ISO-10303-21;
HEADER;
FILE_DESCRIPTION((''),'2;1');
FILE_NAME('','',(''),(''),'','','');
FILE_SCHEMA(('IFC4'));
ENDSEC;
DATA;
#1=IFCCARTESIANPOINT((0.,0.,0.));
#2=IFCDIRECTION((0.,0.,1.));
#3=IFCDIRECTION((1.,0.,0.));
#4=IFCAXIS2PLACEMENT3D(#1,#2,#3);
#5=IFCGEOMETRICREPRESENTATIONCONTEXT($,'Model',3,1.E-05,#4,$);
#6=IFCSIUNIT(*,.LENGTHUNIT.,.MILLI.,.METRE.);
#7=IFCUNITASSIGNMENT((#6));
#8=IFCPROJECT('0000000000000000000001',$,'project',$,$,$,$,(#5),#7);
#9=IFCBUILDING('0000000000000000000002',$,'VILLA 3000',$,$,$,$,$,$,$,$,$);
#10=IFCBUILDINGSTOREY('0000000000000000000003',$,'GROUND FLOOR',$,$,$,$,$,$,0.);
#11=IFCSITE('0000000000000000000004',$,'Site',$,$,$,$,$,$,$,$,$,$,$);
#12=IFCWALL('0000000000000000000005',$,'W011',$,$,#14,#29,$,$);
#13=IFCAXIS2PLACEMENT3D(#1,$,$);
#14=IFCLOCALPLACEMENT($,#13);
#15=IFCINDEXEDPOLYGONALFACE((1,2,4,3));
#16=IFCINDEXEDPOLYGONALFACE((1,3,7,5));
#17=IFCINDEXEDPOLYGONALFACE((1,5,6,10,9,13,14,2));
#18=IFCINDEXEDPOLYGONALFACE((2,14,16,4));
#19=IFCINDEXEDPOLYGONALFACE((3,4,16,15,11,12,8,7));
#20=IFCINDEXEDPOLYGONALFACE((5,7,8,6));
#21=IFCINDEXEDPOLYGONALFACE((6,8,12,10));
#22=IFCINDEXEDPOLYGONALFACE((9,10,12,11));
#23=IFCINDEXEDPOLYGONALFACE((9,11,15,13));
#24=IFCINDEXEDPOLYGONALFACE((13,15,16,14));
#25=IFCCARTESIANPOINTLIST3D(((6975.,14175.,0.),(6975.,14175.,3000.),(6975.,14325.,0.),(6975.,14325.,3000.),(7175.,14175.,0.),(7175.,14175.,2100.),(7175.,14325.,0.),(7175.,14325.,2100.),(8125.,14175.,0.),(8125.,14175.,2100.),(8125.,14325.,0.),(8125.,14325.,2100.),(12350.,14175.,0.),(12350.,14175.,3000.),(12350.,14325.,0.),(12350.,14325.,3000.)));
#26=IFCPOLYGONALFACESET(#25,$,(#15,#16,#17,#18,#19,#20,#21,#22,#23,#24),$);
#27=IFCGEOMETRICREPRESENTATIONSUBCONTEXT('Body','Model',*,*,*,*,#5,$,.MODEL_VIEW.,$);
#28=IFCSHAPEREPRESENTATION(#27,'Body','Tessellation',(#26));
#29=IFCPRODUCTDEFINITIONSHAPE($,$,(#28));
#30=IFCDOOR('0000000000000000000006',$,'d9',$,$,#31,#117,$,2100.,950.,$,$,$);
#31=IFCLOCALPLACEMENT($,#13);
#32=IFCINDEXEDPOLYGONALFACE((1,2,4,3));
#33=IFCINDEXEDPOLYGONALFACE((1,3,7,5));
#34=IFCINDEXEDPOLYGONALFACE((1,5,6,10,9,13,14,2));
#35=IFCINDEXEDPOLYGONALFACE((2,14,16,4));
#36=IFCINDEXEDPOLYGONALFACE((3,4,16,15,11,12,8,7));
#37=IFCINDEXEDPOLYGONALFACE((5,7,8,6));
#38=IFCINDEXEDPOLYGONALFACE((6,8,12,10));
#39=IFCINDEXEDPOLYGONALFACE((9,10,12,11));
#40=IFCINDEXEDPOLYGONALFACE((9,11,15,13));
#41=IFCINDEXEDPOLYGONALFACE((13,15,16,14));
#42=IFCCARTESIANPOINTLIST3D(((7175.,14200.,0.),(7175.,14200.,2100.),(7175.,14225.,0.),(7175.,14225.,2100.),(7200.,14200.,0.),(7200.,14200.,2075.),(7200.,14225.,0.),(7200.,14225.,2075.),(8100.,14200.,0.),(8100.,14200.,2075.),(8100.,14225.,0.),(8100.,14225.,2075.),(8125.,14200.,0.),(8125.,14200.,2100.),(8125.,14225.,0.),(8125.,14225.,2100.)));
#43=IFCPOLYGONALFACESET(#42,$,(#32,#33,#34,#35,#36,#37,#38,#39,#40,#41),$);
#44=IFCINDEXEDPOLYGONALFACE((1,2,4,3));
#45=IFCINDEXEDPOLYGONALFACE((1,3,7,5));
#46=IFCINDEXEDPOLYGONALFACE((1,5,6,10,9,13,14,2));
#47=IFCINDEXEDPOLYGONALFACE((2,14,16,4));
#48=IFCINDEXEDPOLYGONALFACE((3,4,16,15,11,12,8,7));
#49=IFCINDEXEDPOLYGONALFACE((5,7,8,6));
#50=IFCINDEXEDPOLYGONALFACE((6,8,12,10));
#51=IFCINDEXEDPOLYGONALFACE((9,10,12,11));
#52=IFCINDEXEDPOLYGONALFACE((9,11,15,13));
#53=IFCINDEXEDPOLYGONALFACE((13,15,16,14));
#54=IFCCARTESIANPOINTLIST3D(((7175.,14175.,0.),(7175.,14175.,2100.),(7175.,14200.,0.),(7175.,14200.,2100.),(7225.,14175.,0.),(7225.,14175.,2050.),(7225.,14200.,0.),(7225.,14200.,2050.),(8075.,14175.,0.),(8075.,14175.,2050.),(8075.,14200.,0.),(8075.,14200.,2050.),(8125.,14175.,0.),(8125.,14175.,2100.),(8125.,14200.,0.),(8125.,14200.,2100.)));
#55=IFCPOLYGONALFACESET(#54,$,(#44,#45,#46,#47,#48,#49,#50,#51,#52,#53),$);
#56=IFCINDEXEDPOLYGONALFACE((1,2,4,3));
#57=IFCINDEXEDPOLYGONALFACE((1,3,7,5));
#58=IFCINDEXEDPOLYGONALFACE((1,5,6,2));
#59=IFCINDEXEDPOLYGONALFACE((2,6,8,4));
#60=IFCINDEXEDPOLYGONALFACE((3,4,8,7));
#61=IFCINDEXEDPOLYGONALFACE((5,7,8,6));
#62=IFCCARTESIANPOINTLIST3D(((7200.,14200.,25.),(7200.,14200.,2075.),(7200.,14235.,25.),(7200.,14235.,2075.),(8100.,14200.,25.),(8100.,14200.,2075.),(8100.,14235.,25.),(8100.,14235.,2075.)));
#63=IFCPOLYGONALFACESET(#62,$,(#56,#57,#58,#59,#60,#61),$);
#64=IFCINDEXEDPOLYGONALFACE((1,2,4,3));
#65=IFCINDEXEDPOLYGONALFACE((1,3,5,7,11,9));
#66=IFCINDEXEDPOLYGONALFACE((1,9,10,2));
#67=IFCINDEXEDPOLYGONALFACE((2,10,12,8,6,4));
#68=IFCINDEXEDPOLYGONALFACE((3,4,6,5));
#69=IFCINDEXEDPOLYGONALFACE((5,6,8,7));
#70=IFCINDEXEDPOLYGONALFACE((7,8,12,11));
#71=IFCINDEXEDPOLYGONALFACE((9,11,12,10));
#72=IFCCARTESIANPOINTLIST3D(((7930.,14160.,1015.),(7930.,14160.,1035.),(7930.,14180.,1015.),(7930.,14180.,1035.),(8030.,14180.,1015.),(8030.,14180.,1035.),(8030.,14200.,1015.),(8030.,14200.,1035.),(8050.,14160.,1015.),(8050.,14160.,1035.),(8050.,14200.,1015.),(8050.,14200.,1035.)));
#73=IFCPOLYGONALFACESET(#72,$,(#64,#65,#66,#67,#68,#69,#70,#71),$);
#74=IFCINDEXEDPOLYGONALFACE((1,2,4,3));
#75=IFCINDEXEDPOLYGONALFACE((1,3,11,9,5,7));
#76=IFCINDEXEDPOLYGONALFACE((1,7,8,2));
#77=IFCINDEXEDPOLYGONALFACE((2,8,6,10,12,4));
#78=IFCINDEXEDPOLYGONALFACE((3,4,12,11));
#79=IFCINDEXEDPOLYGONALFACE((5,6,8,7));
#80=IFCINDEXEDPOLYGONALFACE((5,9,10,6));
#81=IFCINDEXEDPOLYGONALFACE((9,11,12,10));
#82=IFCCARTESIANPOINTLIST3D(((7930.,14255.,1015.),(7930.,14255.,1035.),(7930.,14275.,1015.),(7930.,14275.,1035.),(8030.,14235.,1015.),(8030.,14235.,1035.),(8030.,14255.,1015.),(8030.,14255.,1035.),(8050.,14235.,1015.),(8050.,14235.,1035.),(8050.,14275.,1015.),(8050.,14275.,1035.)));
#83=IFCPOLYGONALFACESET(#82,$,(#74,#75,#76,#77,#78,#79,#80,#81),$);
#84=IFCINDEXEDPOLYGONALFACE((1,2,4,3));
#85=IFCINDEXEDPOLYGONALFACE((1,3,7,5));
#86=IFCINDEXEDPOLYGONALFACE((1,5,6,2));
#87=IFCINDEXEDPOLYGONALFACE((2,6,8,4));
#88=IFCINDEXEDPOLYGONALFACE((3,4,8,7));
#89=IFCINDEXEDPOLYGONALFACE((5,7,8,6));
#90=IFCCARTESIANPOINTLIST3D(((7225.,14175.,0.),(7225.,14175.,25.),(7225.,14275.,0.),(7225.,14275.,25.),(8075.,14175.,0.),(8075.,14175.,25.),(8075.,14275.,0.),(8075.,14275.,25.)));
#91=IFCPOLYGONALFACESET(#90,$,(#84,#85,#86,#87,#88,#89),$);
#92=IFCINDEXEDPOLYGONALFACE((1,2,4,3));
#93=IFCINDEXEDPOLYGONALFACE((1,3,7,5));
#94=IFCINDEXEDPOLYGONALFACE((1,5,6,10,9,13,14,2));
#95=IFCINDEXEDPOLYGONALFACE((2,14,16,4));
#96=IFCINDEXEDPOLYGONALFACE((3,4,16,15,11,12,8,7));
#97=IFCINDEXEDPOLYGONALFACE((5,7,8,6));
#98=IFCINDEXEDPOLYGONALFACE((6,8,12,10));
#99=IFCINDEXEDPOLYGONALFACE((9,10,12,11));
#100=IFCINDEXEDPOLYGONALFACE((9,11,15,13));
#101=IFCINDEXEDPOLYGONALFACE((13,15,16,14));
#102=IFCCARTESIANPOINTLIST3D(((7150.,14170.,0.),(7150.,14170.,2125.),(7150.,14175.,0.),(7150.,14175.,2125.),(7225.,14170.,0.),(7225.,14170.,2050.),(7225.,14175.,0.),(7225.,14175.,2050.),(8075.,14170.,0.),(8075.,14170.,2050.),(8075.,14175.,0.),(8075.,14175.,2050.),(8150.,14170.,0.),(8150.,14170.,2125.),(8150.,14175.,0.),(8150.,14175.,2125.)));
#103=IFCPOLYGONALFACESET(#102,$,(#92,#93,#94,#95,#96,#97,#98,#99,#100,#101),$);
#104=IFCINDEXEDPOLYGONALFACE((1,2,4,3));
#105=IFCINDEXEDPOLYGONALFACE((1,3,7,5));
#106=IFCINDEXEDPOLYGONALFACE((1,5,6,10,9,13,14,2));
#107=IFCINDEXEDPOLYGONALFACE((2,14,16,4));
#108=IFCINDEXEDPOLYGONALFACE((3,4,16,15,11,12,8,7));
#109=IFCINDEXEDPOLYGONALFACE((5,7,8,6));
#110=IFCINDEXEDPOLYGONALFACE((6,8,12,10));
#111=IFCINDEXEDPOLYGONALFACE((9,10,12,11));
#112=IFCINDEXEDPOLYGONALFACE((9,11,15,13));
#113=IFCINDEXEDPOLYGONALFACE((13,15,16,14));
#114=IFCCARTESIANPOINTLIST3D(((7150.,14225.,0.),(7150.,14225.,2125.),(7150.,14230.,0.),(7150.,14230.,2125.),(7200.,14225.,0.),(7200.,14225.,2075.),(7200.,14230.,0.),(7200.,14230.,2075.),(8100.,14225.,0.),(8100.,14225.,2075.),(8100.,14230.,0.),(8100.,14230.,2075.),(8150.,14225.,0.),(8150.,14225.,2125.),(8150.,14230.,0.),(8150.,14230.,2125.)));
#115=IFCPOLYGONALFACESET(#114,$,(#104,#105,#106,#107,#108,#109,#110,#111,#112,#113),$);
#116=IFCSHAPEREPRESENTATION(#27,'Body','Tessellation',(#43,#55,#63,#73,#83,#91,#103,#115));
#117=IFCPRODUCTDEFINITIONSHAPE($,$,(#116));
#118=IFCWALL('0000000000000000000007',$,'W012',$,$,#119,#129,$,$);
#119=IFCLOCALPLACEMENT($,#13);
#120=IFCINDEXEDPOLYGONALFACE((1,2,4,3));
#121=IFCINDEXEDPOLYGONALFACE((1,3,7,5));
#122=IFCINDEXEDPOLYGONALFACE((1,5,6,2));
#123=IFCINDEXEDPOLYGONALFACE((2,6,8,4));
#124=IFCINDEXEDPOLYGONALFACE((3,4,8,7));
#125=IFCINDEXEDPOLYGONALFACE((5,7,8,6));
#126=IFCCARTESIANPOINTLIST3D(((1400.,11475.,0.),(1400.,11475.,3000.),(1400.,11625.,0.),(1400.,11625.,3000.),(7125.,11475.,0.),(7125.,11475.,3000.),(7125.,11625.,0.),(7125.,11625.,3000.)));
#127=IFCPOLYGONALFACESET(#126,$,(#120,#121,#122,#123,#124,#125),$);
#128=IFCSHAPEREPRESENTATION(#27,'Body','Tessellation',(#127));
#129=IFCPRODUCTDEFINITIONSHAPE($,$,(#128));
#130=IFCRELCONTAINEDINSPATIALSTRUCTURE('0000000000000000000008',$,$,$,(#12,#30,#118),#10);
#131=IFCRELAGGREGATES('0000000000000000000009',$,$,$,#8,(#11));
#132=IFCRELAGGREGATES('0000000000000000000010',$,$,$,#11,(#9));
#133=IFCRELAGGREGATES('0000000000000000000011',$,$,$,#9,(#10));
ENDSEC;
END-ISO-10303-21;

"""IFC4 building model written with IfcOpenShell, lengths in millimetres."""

from ifc_helpers import new_model, si_unit, frame, origin_with_axes, place, context, subcontext, project, spatial, line, indexed_curve, outline, extrude, element, fill, save


model = new_model("IFC4")

# Units and contexts
model_context = context("Model", 3, precision=1e-05, world=origin_with_axes())
body_context = subcontext(model_context, "Body", "Model", "MODEL_VIEW")
ifc_project = project(units=[si_unit("LENGTHUNIT", "METRE", prefix="MILLI")], contexts=[model_context])

# Site, building, storey
site = spatial("IfcSite", under=ifc_project, Name="Site")
building = spatial("IfcBuilding", under=site, Name="VILLA 3000")
storey = spatial("IfcBuildingStorey", under=building, Name="GROUND FLOOR", Elevation=0.0)

# Wall, opening, door
wall_1_placement = place(None, frame((6975.0, 14250.0, 0.0), z_axis=(0.0, 0.0, 1.0), x_axis=(1.0, 0.0, 0.0)))
wall_1 = element("IfcWall", 1, at=wall_1_placement, inside=storey, Name="W011", context=body_context, shape_type="SweptSolid", body=[
    extrude(outline(indexed_curve([(0.0, 0.0), (0.0, 150.0), (5375.0, 150.0), (5375.0, 0.0), (0.0, 0.0)], self_intersect=False)), frame((0.0, -75.0, 0.0), z_axis=(0.0, 0.0, 1.0), x_axis=(1.0, 0.0, 0.0)), (0.0, 0.0, 1.0), 3000.0),
])
opening_1_placement = place(wall_1_placement, frame((200.0, 0.0, 0.0), z_axis=(0.0, 0.0, 1.0), x_axis=(1.0, 0.0, 0.0)))
opening_1 = element("IfcOpeningElement", 2, at=opening_1_placement, cuts=wall_1, context=body_context, shape_type="SweptSolid", body=[
    extrude(outline(indexed_curve([(0.0, 0.0), (0.0, 250.0), (950.0, 250.0), (950.0, 0.0), (0.0, 0.0)], self_intersect=False)), frame((0.0, -125.0, 0.0), z_axis=(0.0, 0.0, 1.0), x_axis=(1.0, 0.0, 0.0)), (0.0, 0.0, 1.0), 2100.0),
])
door_1_placement = place(None, frame((7175.0, 14175.0, 0.0), z_axis=(0.0, 0.0, 1.0), x_axis=(1.0, 0.0, 0.0)))
door_1 = element("IfcDoor", 3, at=door_1_placement, inside=storey, Name="d9", OverallHeight=2100.0, OverallWidth=950.0, context=body_context, shape_type="SweptSolid", body=[
    extrude(outline(indexed_curve([(0.0, 0.0), (0.0, 2100.0), (950.0, 2100.0), (950.0, 0.0), (925.0, 0.0), (925.0, 2075.0), (25.0, 2075.0), (25.0, 0.0)], segments=[line(1, 2, 3, 4, 5, 6, 7, 8, 1)])), frame((0.0, 25.0, 0.0), z_axis=(0.0, -1.0, 0.0), x_axis=(1.0, 0.0, 0.0)), (0.0, 0.0, -1.0), 25.0),
    extrude(outline(indexed_curve([(0.0, 0.0), (0.0, 2100.0), (950.0, 2100.0), (950.0, 0.0), (900.0, 0.0), (900.0, 2050.0), (50.0, 2050.0), (50.0, 0.0)], segments=[line(1, 2, 3, 4, 5, 6, 7, 8, 1)])), frame((0.0, 0.0, 0.0), z_axis=(0.0, -1.0, 0.0), x_axis=(1.0, 0.0, 0.0)), (0.0, 0.0, -1.0), 25.0),
    extrude(outline(indexed_curve([(0.0, 0.0), (900.0, 0.0), (900.0, 35.0), (0.0, 35.0)], segments=[line(1, 2, 3, 4, 1)])), frame((25.0, 25.0, 25.0), z_axis=(0.0, 0.0, 1.0), x_axis=(1.0, 0.0, 0.0)), (0.0, 0.0, 1.0), 2050.0),
    extrude(outline(indexed_curve([(0.0, 0.0), (0.0, -40.0), (-120.0, -40.0), (-120.0, -20.0), (-20.0, -20.0), (-20.0, 0.0)], segments=[line(1, 2, 3, 4, 5, 6, 1)])), frame((875.0, 25.0, 1015.0), z_axis=(0.0, 0.0, 1.0), x_axis=(1.0, 0.0, 0.0)), (0.0, 0.0, 1.0), 20.0),
    extrude(outline(indexed_curve([(0.0, 0.0), (0.0, 40.0), (-120.0, 40.0), (-120.0, 20.0), (-20.0, 20.0), (-20.0, 0.0)], segments=[line(1, 2, 3, 4, 5, 6, 1)])), frame((875.0, 60.0, 1015.0), z_axis=(0.0, 0.0, 1.0), x_axis=(1.0, 0.0, 0.0)), (0.0, 0.0, 1.0), 20.0),
    extrude(outline(indexed_curve([(0.0, 0.0), (850.0, 0.0), (850.0, 100.0), (0.0, 100.0)], segments=[line(1, 2, 3, 4, 1)])), frame((50.0, 0.0, 0.0), z_axis=(0.0, 0.0, 1.0), x_axis=(1.0, 0.0, 0.0)), (0.0, 0.0, 1.0), 25.0),
    extrude(outline(indexed_curve([(0.0, 0.0), (0.0, 2125.0), (1000.0, 2125.0), (1000.0, 0.0), (925.0, 0.0), (925.0, 2050.0), (75.0, 2050.0), (75.0, 0.0)], segments=[line(1, 2, 3, 4, 5, 6, 7, 8, 1)])), frame((-25.0, -5.0, 0.0), z_axis=(0.0, -1.0, 0.0), x_axis=(1.0, 0.0, 0.0)), (0.0, 0.0, -1.0), 5.0),
    extrude(outline(indexed_curve([(0.0, 0.0), (0.0, 2125.0), (1000.0, 2125.0), (1000.0, 0.0), (950.0, 0.0), (950.0, 2075.0), (50.0, 2075.0), (50.0, 0.0)], segments=[line(1, 2, 3, 4, 5, 6, 7, 8, 1)])), frame((-25.0, 50.0, 0.0), z_axis=(0.0, -1.0, 0.0), x_axis=(1.0, 0.0, 0.0)), (0.0, 0.0, -1.0), 5.0),
])
fill(opening_1, door_1)

# Wall
wall_2_placement = place(None, frame((1400.0, 11550.0, 0.0), z_axis=(0.0, 0.0, 1.0), x_axis=(1.0, 0.0, 0.0)))
element("IfcWall", 4, at=wall_2_placement, inside=storey, Name="W012", context=body_context, shape_type="SweptSolid", body=[
    extrude(outline(indexed_curve([(0.0, 0.0), (0.0, 150.0), (5725.0, 150.0), (5725.0, 0.0), (0.0, 0.0)], self_intersect=False)), frame((0.0, -75.0, 0.0), z_axis=(0.0, 0.0, 1.0), x_axis=(1.0, 0.0, 0.0)), (0.0, 0.0, 1.0), 3000.0),
])

save(model, "model.ifc")
